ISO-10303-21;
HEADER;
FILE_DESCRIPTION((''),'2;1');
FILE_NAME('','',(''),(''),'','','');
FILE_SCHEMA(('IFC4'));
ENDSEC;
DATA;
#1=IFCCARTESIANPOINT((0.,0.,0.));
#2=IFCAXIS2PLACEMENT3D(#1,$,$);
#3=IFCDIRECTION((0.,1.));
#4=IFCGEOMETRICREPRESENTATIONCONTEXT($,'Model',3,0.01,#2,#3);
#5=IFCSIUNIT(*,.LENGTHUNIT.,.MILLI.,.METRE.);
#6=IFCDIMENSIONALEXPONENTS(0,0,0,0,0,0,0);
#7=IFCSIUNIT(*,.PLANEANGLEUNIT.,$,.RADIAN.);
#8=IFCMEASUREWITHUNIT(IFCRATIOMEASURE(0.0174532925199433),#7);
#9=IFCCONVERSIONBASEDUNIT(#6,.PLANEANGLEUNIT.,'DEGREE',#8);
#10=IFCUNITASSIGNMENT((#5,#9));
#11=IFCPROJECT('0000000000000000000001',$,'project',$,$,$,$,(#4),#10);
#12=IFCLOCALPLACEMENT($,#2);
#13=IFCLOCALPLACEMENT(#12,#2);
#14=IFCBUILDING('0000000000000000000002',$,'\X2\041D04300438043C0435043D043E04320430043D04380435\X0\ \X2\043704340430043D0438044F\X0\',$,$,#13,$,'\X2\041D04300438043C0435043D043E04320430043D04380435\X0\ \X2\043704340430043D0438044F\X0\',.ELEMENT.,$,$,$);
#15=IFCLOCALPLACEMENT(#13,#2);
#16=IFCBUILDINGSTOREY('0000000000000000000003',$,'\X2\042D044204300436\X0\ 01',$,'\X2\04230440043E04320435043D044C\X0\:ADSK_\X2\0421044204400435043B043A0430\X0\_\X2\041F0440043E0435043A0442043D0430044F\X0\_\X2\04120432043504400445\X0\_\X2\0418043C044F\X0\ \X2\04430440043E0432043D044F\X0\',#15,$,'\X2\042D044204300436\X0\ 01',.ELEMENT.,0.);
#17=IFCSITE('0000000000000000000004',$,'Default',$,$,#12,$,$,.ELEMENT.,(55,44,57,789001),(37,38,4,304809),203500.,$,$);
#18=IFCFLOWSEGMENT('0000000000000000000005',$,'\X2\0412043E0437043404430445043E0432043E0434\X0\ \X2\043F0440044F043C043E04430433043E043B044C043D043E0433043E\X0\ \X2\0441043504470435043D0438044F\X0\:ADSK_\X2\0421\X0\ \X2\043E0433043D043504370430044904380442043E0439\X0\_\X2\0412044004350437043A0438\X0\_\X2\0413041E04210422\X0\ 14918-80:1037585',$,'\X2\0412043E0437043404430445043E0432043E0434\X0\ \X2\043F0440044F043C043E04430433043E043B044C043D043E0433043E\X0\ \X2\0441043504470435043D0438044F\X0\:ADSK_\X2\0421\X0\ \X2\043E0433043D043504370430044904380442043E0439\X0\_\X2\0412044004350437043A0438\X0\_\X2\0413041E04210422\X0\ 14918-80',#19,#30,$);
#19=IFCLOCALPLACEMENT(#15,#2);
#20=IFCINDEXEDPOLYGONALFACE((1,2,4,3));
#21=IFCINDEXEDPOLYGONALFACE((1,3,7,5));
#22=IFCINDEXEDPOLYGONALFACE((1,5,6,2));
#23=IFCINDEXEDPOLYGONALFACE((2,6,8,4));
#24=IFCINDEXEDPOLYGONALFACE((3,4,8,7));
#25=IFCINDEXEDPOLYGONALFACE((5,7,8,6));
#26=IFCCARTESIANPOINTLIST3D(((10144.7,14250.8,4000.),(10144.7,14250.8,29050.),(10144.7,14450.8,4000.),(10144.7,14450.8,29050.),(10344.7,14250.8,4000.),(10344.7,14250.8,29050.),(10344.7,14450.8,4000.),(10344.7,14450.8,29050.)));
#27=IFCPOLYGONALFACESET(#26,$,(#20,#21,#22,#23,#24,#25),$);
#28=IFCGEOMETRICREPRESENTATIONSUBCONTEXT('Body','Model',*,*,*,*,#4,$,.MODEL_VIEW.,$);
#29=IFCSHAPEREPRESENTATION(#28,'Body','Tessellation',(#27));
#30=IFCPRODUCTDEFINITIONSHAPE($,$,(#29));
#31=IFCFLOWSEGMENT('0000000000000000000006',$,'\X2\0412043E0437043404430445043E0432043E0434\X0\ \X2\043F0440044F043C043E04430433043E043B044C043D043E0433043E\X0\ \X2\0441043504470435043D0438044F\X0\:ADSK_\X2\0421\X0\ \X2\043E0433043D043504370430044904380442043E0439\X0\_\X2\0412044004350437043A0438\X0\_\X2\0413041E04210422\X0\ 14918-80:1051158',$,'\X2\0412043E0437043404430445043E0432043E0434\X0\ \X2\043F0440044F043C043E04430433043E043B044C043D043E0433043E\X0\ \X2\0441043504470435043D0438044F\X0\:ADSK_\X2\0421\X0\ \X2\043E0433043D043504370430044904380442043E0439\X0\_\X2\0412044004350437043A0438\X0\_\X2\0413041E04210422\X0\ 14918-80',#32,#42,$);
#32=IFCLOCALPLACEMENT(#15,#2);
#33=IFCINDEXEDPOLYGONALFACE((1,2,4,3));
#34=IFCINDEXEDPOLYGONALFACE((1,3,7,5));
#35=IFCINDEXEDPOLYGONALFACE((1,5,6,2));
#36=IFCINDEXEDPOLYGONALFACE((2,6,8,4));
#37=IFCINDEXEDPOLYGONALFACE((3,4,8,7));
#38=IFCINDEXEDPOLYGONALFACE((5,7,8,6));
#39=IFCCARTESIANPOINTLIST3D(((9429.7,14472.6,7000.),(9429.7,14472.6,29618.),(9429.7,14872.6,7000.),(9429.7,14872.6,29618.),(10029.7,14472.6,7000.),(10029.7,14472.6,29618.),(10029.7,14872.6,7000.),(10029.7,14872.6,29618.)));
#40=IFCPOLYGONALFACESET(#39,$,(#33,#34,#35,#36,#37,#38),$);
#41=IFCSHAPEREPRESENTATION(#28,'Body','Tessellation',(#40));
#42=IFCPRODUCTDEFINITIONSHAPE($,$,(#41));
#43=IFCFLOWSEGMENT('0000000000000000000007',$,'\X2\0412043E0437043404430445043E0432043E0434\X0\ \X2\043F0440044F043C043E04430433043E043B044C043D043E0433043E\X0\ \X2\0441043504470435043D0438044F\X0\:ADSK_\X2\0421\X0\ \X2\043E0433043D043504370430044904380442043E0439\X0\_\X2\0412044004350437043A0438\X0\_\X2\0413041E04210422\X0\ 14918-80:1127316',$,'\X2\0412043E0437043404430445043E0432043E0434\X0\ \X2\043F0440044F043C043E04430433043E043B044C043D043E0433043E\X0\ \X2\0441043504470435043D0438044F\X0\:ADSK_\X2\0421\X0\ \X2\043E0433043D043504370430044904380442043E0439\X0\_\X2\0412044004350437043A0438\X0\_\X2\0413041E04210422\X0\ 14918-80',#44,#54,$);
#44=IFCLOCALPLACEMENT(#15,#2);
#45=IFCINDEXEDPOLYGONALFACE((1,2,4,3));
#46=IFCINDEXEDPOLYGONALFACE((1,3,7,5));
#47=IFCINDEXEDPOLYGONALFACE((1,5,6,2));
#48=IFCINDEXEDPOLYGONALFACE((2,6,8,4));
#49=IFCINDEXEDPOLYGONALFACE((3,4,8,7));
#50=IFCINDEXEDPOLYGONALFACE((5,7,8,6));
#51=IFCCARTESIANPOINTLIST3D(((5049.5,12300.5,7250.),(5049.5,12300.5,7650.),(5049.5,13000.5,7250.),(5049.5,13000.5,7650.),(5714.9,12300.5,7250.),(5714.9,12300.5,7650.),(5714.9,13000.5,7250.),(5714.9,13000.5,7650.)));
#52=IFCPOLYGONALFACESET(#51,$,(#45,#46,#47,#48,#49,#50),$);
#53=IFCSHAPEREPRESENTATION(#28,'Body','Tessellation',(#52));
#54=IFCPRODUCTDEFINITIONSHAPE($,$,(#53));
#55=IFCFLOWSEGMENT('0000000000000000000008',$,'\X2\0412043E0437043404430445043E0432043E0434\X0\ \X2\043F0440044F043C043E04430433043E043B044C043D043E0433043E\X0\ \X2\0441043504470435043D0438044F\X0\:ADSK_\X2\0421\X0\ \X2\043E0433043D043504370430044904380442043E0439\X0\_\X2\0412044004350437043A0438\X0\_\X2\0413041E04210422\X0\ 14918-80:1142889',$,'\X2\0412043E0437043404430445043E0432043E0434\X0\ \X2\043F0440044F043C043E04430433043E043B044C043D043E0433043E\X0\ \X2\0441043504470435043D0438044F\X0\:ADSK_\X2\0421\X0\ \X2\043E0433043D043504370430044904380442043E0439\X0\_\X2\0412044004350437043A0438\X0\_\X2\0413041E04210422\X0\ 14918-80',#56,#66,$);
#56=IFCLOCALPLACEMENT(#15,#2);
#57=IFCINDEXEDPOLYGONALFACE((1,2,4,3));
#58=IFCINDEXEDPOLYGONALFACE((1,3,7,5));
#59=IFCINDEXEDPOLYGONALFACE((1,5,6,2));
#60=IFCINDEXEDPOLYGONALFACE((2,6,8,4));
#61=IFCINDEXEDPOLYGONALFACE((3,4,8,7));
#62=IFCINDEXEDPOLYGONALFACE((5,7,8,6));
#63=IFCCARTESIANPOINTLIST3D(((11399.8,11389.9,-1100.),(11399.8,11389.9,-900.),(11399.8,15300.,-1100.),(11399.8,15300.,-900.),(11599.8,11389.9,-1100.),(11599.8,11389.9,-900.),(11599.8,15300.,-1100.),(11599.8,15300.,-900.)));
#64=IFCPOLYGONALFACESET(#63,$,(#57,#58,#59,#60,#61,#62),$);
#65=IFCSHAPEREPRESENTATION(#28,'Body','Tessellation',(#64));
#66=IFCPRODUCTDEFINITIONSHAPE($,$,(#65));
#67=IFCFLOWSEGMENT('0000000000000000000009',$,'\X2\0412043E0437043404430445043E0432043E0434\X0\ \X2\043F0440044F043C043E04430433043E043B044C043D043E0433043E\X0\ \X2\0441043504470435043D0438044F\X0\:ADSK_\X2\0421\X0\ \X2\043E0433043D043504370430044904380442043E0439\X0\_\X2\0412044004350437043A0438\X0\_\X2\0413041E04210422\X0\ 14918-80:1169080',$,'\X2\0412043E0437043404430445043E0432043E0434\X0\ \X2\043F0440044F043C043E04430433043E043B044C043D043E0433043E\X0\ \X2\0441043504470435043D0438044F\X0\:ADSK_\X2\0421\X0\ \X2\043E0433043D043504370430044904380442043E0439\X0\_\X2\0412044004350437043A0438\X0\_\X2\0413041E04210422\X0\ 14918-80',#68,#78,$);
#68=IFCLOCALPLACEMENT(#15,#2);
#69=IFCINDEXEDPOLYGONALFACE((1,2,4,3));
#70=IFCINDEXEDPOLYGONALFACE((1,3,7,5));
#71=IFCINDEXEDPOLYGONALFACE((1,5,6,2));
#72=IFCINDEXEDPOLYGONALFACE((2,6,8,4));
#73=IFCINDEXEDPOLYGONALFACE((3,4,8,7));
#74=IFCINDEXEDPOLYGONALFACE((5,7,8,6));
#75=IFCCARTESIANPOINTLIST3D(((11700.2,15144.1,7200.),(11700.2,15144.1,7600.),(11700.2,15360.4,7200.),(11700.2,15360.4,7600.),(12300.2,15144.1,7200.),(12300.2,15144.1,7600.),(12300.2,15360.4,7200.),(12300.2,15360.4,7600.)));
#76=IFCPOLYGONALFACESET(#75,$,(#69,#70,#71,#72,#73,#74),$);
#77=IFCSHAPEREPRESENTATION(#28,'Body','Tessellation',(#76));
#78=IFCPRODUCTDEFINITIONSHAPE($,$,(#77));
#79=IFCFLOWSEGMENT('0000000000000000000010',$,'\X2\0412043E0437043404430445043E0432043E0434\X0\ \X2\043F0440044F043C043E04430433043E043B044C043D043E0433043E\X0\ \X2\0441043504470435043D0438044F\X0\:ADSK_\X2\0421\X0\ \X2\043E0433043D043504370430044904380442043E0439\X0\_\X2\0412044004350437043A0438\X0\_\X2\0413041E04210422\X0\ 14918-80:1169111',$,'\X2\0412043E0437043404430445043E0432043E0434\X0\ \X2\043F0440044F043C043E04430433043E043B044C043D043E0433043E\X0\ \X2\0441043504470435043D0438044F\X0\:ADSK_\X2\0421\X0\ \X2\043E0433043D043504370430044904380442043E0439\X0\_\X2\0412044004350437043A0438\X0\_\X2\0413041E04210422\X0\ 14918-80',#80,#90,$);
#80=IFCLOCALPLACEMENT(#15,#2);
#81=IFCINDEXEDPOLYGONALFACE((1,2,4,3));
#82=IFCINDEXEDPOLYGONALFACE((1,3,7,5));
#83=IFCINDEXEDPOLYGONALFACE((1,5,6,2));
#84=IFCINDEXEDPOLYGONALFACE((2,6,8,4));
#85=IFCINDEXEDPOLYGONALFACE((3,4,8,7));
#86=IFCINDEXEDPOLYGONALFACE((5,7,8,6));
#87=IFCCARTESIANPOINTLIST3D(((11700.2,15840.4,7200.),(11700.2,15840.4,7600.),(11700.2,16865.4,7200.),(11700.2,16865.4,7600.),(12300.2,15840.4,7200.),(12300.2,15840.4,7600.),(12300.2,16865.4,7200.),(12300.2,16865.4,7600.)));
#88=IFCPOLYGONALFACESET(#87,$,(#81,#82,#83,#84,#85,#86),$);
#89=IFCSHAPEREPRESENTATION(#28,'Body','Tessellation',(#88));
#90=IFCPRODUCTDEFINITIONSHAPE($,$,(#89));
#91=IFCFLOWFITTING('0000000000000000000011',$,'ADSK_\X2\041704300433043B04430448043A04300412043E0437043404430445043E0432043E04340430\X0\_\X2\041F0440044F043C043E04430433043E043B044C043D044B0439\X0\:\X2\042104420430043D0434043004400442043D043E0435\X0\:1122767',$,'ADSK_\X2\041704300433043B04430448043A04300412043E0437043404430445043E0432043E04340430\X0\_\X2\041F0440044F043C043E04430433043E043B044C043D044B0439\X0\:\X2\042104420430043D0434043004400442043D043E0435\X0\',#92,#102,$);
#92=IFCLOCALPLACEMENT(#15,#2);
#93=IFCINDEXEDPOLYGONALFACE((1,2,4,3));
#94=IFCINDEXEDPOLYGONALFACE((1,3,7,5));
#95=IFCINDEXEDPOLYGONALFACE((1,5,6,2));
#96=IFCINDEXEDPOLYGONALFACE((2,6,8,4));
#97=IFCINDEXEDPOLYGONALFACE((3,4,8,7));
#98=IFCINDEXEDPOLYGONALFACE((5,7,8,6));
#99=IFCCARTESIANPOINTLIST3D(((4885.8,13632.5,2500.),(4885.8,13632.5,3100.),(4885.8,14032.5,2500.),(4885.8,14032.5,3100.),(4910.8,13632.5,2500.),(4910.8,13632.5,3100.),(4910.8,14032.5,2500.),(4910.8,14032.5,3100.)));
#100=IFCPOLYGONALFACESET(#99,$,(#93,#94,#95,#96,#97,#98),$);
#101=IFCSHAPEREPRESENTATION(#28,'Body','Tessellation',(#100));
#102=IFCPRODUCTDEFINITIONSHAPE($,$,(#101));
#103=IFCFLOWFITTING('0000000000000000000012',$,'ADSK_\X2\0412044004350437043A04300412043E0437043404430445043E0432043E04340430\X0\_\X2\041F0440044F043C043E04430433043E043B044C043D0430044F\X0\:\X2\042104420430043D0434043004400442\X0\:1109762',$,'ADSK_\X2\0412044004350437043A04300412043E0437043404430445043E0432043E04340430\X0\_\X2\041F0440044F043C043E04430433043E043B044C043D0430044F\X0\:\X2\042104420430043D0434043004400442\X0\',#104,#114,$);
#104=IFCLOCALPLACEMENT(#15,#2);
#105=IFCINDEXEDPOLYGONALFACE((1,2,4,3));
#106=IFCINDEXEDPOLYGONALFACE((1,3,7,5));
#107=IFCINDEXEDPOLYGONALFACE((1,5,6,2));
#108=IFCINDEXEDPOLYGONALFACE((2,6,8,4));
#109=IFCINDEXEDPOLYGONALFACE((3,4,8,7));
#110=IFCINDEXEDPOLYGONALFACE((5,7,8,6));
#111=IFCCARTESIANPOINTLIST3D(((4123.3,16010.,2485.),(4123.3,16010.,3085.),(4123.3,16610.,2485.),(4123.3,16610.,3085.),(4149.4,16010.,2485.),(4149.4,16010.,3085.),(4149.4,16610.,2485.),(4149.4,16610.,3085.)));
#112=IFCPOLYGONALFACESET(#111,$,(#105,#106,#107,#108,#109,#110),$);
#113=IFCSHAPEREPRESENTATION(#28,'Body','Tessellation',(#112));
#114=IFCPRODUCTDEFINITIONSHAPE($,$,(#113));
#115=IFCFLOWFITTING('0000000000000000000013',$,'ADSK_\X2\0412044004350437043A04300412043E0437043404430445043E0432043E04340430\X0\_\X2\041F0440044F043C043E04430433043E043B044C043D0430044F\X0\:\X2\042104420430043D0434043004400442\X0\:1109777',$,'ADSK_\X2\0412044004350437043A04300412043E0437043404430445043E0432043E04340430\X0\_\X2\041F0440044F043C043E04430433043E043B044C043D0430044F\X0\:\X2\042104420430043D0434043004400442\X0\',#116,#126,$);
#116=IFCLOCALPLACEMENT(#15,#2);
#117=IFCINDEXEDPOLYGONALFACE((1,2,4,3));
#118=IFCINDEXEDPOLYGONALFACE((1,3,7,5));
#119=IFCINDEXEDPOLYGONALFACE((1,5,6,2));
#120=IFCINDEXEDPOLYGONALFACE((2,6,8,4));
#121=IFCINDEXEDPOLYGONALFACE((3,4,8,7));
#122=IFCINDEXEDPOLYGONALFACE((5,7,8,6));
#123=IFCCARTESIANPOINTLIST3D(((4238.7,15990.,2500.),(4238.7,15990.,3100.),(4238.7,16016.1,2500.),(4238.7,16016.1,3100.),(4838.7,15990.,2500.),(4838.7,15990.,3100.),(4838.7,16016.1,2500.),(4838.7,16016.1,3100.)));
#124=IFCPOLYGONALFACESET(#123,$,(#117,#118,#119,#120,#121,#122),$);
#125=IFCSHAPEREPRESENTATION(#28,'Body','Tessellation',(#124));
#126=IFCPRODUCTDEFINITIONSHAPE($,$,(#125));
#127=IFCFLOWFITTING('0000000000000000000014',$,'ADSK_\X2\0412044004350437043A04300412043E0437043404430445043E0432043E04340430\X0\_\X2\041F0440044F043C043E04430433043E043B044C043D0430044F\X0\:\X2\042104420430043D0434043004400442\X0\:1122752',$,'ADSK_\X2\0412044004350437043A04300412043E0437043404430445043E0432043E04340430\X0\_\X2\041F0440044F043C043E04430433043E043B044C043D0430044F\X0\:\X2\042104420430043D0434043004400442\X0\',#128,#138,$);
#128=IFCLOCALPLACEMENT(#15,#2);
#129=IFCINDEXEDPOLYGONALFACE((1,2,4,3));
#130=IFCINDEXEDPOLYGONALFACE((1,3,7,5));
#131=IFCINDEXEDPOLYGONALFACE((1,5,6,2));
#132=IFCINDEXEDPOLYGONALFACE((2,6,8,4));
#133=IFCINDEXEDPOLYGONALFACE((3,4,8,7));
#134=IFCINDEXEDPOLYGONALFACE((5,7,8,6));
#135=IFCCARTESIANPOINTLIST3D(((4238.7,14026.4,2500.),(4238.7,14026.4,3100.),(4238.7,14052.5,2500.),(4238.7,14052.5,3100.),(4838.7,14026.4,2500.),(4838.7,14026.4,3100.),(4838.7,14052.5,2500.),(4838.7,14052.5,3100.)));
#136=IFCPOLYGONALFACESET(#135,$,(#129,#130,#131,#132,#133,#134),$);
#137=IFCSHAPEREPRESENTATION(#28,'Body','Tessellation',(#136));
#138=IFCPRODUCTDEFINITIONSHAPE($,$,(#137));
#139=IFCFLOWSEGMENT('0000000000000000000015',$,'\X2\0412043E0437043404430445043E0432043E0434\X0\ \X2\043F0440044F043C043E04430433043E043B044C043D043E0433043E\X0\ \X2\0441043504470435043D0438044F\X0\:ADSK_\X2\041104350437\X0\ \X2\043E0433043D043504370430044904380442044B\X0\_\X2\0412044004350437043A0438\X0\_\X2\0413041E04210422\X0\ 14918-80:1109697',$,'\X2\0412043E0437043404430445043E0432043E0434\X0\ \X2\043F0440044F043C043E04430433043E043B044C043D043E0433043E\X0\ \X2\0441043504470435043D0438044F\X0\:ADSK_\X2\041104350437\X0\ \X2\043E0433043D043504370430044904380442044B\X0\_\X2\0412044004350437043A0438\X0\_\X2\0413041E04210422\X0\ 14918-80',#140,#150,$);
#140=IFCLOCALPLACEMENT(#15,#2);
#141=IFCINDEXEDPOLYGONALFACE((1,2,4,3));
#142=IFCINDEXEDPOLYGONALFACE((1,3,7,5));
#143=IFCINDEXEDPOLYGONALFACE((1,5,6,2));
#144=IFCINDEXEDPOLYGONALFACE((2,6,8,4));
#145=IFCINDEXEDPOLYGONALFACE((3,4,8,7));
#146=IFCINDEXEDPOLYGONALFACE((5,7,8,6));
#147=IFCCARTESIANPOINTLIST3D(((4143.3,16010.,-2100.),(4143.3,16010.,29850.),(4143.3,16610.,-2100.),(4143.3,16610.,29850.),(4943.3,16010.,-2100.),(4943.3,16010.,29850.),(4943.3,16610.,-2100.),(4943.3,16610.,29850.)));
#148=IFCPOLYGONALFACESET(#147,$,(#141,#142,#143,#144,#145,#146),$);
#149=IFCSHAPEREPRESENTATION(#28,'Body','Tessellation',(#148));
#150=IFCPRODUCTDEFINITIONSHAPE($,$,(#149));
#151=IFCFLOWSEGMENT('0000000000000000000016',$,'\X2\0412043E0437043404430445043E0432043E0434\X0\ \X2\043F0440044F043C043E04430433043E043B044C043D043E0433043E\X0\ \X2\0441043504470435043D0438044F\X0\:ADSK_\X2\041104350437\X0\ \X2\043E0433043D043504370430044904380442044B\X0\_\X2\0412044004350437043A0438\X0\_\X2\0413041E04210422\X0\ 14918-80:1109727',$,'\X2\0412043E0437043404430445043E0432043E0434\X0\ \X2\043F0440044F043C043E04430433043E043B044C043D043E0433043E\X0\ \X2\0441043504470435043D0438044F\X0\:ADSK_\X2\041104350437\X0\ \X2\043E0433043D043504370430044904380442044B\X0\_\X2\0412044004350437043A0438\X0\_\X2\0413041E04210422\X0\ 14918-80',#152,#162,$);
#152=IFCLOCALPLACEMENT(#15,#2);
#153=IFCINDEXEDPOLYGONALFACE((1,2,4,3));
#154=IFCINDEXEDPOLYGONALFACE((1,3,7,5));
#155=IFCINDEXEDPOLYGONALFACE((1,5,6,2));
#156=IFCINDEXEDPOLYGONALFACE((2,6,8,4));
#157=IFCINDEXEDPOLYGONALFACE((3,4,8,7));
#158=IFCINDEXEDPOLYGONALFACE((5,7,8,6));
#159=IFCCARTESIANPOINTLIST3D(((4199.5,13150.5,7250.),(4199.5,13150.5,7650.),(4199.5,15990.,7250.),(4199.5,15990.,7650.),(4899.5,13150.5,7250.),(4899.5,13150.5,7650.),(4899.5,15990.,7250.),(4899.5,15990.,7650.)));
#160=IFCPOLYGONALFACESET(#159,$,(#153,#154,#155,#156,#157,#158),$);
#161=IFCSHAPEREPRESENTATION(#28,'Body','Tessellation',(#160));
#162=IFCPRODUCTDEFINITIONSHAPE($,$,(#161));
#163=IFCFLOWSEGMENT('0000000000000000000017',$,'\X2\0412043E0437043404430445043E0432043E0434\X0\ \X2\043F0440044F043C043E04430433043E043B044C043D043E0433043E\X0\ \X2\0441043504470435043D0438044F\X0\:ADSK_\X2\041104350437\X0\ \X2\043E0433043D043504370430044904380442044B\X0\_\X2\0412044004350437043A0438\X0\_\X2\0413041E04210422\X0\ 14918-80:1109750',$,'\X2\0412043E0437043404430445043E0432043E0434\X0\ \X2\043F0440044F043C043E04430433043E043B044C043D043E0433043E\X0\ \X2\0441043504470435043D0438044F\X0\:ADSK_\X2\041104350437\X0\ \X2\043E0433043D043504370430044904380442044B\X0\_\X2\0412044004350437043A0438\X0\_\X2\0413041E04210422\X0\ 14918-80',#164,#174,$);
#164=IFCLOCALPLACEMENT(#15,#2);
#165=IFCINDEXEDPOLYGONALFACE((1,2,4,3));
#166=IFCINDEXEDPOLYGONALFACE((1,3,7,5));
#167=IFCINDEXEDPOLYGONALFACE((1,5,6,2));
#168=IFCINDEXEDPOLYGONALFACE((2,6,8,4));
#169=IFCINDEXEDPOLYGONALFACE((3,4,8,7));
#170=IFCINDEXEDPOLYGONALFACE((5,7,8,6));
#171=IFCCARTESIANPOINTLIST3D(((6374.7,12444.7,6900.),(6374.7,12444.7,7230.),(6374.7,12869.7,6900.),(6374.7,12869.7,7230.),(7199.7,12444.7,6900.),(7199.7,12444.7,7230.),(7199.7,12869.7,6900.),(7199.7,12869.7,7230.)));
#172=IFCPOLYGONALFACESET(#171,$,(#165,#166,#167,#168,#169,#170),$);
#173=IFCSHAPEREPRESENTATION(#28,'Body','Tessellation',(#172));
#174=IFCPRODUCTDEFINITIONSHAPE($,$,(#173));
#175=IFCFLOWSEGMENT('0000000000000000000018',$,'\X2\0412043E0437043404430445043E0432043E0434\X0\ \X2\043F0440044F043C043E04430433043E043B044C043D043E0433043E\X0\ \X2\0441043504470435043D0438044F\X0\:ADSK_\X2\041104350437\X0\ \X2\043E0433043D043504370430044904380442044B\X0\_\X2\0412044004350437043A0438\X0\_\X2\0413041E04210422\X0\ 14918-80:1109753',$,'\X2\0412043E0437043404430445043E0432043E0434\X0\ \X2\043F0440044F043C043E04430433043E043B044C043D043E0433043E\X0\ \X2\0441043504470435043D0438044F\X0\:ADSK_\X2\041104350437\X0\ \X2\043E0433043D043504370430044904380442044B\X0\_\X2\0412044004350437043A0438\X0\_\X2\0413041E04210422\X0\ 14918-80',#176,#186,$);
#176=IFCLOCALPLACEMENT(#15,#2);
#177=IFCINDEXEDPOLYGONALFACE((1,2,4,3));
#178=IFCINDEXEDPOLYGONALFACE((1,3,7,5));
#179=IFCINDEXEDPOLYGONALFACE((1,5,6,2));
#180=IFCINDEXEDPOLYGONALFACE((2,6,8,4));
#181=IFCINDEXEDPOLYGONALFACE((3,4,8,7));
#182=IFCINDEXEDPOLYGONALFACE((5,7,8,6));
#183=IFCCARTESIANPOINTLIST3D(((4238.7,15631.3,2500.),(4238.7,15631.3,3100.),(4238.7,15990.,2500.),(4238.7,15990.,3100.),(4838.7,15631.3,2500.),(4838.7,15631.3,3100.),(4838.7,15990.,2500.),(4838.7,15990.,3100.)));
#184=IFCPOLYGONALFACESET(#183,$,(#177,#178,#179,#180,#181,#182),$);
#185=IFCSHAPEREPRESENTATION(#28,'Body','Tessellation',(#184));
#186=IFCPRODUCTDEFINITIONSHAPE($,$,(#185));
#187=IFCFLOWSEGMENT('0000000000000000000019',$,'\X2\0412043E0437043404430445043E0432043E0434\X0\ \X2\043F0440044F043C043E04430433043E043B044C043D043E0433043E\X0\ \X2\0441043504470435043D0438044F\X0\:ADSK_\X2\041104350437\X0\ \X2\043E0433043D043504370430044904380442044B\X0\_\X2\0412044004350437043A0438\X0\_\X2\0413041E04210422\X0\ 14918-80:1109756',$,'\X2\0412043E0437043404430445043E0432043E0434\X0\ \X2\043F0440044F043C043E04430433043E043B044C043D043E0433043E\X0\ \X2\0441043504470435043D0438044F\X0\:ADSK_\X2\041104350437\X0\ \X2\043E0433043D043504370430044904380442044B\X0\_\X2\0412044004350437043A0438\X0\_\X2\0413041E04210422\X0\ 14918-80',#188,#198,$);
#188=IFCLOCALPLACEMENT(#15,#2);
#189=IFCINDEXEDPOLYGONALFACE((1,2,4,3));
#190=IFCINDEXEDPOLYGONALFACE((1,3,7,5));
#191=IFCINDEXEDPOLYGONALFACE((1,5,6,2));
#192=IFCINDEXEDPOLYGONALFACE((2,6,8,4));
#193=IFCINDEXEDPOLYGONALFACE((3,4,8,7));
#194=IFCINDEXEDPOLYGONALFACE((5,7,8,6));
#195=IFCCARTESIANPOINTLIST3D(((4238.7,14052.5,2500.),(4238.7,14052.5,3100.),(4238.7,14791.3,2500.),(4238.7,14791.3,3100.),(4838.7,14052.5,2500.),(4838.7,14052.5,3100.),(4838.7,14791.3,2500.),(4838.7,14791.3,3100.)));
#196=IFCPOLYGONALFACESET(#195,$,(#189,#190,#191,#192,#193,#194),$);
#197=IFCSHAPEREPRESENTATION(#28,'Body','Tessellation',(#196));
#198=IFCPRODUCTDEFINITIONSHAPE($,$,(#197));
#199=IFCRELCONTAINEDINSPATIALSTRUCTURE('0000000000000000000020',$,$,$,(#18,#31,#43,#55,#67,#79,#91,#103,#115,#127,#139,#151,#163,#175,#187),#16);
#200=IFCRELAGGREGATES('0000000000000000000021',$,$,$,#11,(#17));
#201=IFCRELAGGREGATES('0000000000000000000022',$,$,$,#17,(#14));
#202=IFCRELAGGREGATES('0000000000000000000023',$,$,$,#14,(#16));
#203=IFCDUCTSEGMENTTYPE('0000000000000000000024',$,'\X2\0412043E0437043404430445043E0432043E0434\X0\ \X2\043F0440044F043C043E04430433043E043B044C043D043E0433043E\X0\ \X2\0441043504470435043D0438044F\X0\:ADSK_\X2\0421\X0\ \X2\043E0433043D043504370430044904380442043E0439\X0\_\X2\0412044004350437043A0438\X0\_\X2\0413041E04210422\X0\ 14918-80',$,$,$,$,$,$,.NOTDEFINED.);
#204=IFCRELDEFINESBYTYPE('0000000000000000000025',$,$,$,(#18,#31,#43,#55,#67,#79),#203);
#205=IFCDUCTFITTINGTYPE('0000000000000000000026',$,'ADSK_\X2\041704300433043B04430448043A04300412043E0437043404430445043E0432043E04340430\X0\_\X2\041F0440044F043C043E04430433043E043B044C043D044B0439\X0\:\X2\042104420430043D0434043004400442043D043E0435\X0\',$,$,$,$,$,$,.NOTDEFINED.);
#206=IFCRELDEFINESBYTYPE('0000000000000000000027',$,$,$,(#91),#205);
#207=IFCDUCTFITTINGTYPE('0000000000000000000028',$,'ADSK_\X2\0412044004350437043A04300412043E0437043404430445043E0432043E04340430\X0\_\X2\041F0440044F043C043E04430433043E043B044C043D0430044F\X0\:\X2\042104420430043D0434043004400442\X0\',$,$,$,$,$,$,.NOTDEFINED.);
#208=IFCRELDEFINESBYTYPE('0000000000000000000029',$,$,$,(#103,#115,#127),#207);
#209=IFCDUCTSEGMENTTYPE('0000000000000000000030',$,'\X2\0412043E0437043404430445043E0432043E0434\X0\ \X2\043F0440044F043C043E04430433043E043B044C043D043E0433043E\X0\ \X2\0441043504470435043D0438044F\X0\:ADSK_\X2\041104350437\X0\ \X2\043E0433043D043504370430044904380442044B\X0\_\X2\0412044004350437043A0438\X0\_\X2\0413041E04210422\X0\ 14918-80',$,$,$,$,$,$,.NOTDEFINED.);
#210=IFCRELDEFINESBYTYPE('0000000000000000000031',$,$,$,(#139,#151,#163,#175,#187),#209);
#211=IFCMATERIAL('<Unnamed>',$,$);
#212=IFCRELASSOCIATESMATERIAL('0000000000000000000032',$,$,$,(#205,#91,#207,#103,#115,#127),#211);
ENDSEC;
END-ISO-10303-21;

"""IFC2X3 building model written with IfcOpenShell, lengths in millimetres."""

from ifc_helpers import new_model, entity, si_unit, converted_unit, direction, frame, frame_2d, origin, origin_2d_with_axis, place, context, subcontext, project, spatial, rectangle, extrude, source, transform, mapped, material, type_object, type_shapes, element, save


model = new_model("IFC2X3")

# Units and contexts
model_context = context("Model", 3, precision=0.01, world=origin(), true_north=direction((0.0, 1.0)))
body_context = subcontext(model_context, "Body", "Model", "MODEL_VIEW")
ifc_project = project(units=[si_unit("LENGTHUNIT", "METRE", prefix="MILLI"), converted_unit("PLANEANGLEUNIT", "DEGREE", entity("IfcRatioMeasure", 0.0174532925199433), si_unit("PLANEANGLEUNIT", "RADIAN"), dimensions=[0, 0, 0, 0, 0, 0, 0])], contexts=[model_context])

# Site, building, storey
site_placement = place(None, frame((0.0, 0.0, 0.0)))
site = spatial("IfcSite", under=ifc_project, at=site_placement, Name="Default", CompositionType="ELEMENT", RefLatitude=(55, 44, 57, 789001), RefLongitude=(37, 38, 4, 304809), RefElevation=203500.0)
building_placement = place(site_placement, origin())
building = spatial("IfcBuilding", under=site, at=building_placement, Name="Наименование здания", LongName="Наименование здания", CompositionType="ELEMENT")
storey_placement = place(building_placement, origin())
storey = spatial("IfcBuildingStorey", under=building, at=storey_placement, Name="Этаж 01", ObjectType="Уровень:ADSK_Стрелка_Проектная_Вверх_Имя уровня", LongName="Этаж 01", CompositionType="ELEMENT", Elevation=0.0)

# Flow segments
duct_segment_type_1 = type_object("IfcDuctSegmentType", Name="Воздуховод прямоугольного сечения:ADSK_С огнезащитой_Врезки_ГОСТ 14918-80", PredefinedType="NOTDEFINED")
flow_segment_1_placement = place(storey_placement, frame((10144.7, 14250.8, 4000.0)))
element("IfcFlowSegment", 1, at=flow_segment_1_placement, inside=storey, type_object=duct_segment_type_1, Name="Воздуховод прямоугольного сечения:ADSK_С огнезащитой_Врезки_ГОСТ 14918-80:1037585", ObjectType="Воздуховод прямоугольного сечения:ADSK_С огнезащитой_Врезки_ГОСТ 14918-80", context=body_context, shape_type="SweptSolid", body=[
    extrude(rectangle(XDim=200.0, YDim=200.0, at=frame_2d((0.0, 0.0), x_axis=(1.0, 0.0))), frame((100.0, 100.0, 0.0), z_axis=(0.0, 0.0, 1.0), x_axis=(0.0, -1.0, 0.0)), (0.0, 0.0, 1.0), 25050.0),
])
flow_segment_2_placement = place(storey_placement, frame((9429.7, 14472.6, 7000.0)))
element("IfcFlowSegment", 2, at=flow_segment_2_placement, inside=storey, type_object=duct_segment_type_1, Name="Воздуховод прямоугольного сечения:ADSK_С огнезащитой_Врезки_ГОСТ 14918-80:1051158", ObjectType="Воздуховод прямоугольного сечения:ADSK_С огнезащитой_Врезки_ГОСТ 14918-80", context=body_context, shape_type="SweptSolid", body=[
    extrude(rectangle(XDim=400.0, YDim=600.0, at=frame_2d((0.0, 0.0), x_axis=(1.0, 0.0))), frame((300.0, 200.0, 0.0), z_axis=(0.0, 0.0, 1.0), x_axis=(0.0, 1.0, 0.0)), (0.0, 0.0, 1.0), 22618.0),
])
flow_segment_3_placement = place(storey_placement, frame((5049.5, 12300.5, 7250.0)))
element("IfcFlowSegment", 3, at=flow_segment_3_placement, inside=storey, type_object=duct_segment_type_1, Name="Воздуховод прямоугольного сечения:ADSK_С огнезащитой_Врезки_ГОСТ 14918-80:1127316", ObjectType="Воздуховод прямоугольного сечения:ADSK_С огнезащитой_Врезки_ГОСТ 14918-80", context=body_context, shape_type="SweptSolid", body=[
    extrude(rectangle(XDim=665.5, YDim=700.0, at=frame_2d((0.0, 0.0), x_axis=(1.0, 0.0))), frame((332.7, 350.0, 0.0), z_axis=(0.0, 0.0, 1.0), x_axis=(-1.0, 0.0, 0.0)), (0.0, 0.0, 1.0), 400.0),
])
flow_segment_4_placement = place(storey_placement, frame((11399.8, 11389.9, -1100.0)))
element("IfcFlowSegment", 4, at=flow_segment_4_placement, inside=storey, type_object=duct_segment_type_1, Name="Воздуховод прямоугольного сечения:ADSK_С огнезащитой_Врезки_ГОСТ 14918-80:1142889", ObjectType="Воздуховод прямоугольного сечения:ADSK_С огнезащитой_Врезки_ГОСТ 14918-80", context=body_context, shape_type="SweptSolid", body=[
    extrude(rectangle(XDim=3910.1, YDim=200.0, at=origin_2d_with_axis()), frame((100.0, 1955.0, 0.0), z_axis=(0.0, 0.0, 1.0), x_axis=(0.0, 1.0, 0.0)), (0.0, 0.0, 1.0), 200.0),
])
flow_segment_5_placement = place(storey_placement, frame((11700.2, 15144.1, 7200.0)))
element("IfcFlowSegment", 5, at=flow_segment_5_placement, inside=storey, type_object=duct_segment_type_1, Name="Воздуховод прямоугольного сечения:ADSK_С огнезащитой_Врезки_ГОСТ 14918-80:1169080", ObjectType="Воздуховод прямоугольного сечения:ADSK_С огнезащитой_Врезки_ГОСТ 14918-80", context=body_context, shape_type="SweptSolid", body=[
    extrude(rectangle(XDim=216.3, YDim=600.0, at=frame_2d((0.0, 0.0), x_axis=(1.0, 0.0))), frame((300.0, 108.1, 0.0), z_axis=(0.0, 0.0, 1.0), x_axis=(0.0, -1.0, 0.0)), (0.0, 0.0, 1.0), 400.0),
])
flow_segment_6_placement = place(storey_placement, frame((11700.2, 15840.4, 7200.0)))
element("IfcFlowSegment", 6, at=flow_segment_6_placement, inside=storey, type_object=duct_segment_type_1, Name="Воздуховод прямоугольного сечения:ADSK_С огнезащитой_Врезки_ГОСТ 14918-80:1169111", ObjectType="Воздуховод прямоугольного сечения:ADSK_С огнезащитой_Врезки_ГОСТ 14918-80", context=body_context, shape_type="SweptSolid", body=[
    extrude(rectangle(XDim=1025.0, YDim=600.0, at=frame_2d((0.0, 0.0), x_axis=(1.0, 0.0))), frame((300.0, 512.5, 0.0), z_axis=(0.0, 0.0, 1.0), x_axis=(0.0, 1.0, 0.0)), (0.0, 0.0, 1.0), 400.0),
])

# Flow fittings
ifc_material_1 = material(Name="<Unnamed>")
duct_fitting_type_1 = type_object("IfcDuctFittingType", Name="ADSK_ЗаглушкаВоздуховода_Прямоугольный:Стандартное", PredefinedType="NOTDEFINED", material=ifc_material_1)
shared_shape_1 = source(origin(), body_context, "Body", "SweptSolid", [
    extrude(rectangle(XDim=25.0, YDim=400.0, at=frame_2d((0.0, 0.0), x_axis=(1.0, 0.0))), frame((12.5, 0.0, -300.0)), (0.0, 0.0, 1.0), 600.0),
])
type_shapes(duct_fitting_type_1, [shared_shape_1])
flow_fitting_1_placement = place(storey_placement, frame((4885.8, 13832.5, 2800.0)))
element("IfcFlowFitting", 7, at=flow_fitting_1_placement, inside=storey, type_object=duct_fitting_type_1, material=ifc_material_1, Name="ADSK_ЗаглушкаВоздуховода_Прямоугольный:Стандартное:1122767", ObjectType="ADSK_ЗаглушкаВоздуховода_Прямоугольный:Стандартное", context=body_context, shape_type="MappedRepresentation", body=[
    mapped(shared_shape_1, transform((0.0, 0.0, 0.0), scale=1.0)),
])
duct_fitting_type_2 = type_object("IfcDuctFittingType", Name="ADSK_ВрезкаВоздуховода_Прямоугольная:Стандарт", PredefinedType="NOTDEFINED", material=ifc_material_1)
shared_shape_2 = source(origin(), body_context, "Body", "SweptSolid", [
    extrude(rectangle(XDim=26.1, YDim=600.0, at=frame_2d((0.0, 0.0), x_axis=(1.0, 0.0))), frame((7.0, 0.0, -300.0)), (0.0, 0.0, 1.0), 600.0),
])
type_shapes(duct_fitting_type_2, [shared_shape_2])
for number, where, z_axis, x_axis, name in (
    (8, (4143.3, 16310.0, 2785.0), (0.0, 1.0, 0.0), (-1.0, 0.0, 0.0), "ADSK_ВрезкаВоздуховода_Прямоугольная:Стандарт:1109762"),
    (9, (4538.7, 16010.0, 2800.0), (-1.0, 0.0, 0.0), (0.0, -1.0, 0.0), "ADSK_ВрезкаВоздуховода_Прямоугольная:Стандарт:1109777"),
    (10, (4538.7, 14032.5, 2800.0), (0.0, 0.0, -1.0), (0.0, 1.0, 0.0), "ADSK_ВрезкаВоздуховода_Прямоугольная:Стандарт:1122752"),
):
    element("IfcFlowFitting", number, at=place(storey_placement, frame(where, z_axis=z_axis, x_axis=x_axis)), inside=storey, type_object=duct_fitting_type_2, material=ifc_material_1, Name=name, ObjectType="ADSK_ВрезкаВоздуховода_Прямоугольная:Стандарт", context=body_context, shape_type="MappedRepresentation", body=[
        mapped(shared_shape_2, transform((0.0, 0.0, 0.0), scale=1.0)),
    ])

# Flow segments
duct_segment_type_2 = type_object("IfcDuctSegmentType", Name="Воздуховод прямоугольного сечения:ADSK_Без огнезащиты_Врезки_ГОСТ 14918-80", PredefinedType="NOTDEFINED")
flow_segment_7_placement = place(storey_placement, frame((4143.3, 16010.0, -2100.0)))
element("IfcFlowSegment", 11, at=flow_segment_7_placement, inside=storey, type_object=duct_segment_type_2, Name="Воздуховод прямоугольного сечения:ADSK_Без огнезащиты_Врезки_ГОСТ 14918-80:1109697", ObjectType="Воздуховод прямоугольного сечения:ADSK_Без огнезащиты_Врезки_ГОСТ 14918-80", context=body_context, shape_type="SweptSolid", body=[
    extrude(rectangle(XDim=600.0, YDim=800.0, at=frame_2d((0.0, 0.0), x_axis=(1.0, 0.0))), frame((400.0, 300.0, 0.0), z_axis=(0.0, 0.0, 1.0), x_axis=(0.0, 1.0, 0.0)), (0.0, 0.0, 1.0), 31950.0),
])
flow_segment_8_placement = place(storey_placement, frame((4199.5, 13150.5, 7250.0)))
element("IfcFlowSegment", 12, at=flow_segment_8_placement, inside=storey, type_object=duct_segment_type_2, Name="Воздуховод прямоугольного сечения:ADSK_Без огнезащиты_Врезки_ГОСТ 14918-80:1109727", ObjectType="Воздуховод прямоугольного сечения:ADSK_Без огнезащиты_Врезки_ГОСТ 14918-80", context=body_context, shape_type="SweptSolid", body=[
    extrude(rectangle(XDim=2839.5, YDim=700.0, at=frame_2d((0.0, 0.0), x_axis=(1.0, 0.0))), frame((350.0, 1419.8, 0.0), z_axis=(0.0, 0.0, 1.0), x_axis=(0.0, 1.0, 0.0)), (0.0, 0.0, 1.0), 400.0),
])
flow_segment_9_placement = place(storey_placement, frame((6374.7, 12444.7, 6900.0)))
element("IfcFlowSegment", 13, at=flow_segment_9_placement, inside=storey, type_object=duct_segment_type_2, Name="Воздуховод прямоугольного сечения:ADSK_Без огнезащиты_Врезки_ГОСТ 14918-80:1109750", ObjectType="Воздуховод прямоугольного сечения:ADSK_Без огнезащиты_Врезки_ГОСТ 14918-80", context=body_context, shape_type="SweptSolid", body=[
    extrude(rectangle(XDim=825.0, YDim=425.0, at=frame_2d((0.0, 0.0), x_axis=(1.0, 0.0))), frame((412.5, 212.5, 0.0), z_axis=(0.0, 0.0, 1.0), x_axis=(-1.0, 0.0, 0.0)), (0.0, 0.0, 1.0), 330.0),
])
flow_segment_10_placement = place(storey_placement, frame((4238.7, 15631.3, 2500.0)))
element("IfcFlowSegment", 14, at=flow_segment_10_placement, inside=storey, type_object=duct_segment_type_2, Name="Воздуховод прямоугольного сечения:ADSK_Без огнезащиты_Врезки_ГОСТ 14918-80:1109753", ObjectType="Воздуховод прямоугольного сечения:ADSK_Без огнезащиты_Врезки_ГОСТ 14918-80", context=body_context, shape_type="SweptSolid", body=[
    extrude(rectangle(XDim=358.6, YDim=600.0, at=frame_2d((0.0, 0.0), x_axis=(1.0, 0.0))), frame((300.0, 179.3, 0.0), z_axis=(0.0, 0.0, 1.0), x_axis=(0.0, 1.0, 0.0)), (0.0, 0.0, 1.0), 600.0),
])
flow_segment_11_placement = place(storey_placement, frame((4238.7, 14052.5, 2500.0)))
element("IfcFlowSegment", 15, at=flow_segment_11_placement, inside=storey, type_object=duct_segment_type_2, Name="Воздуховод прямоугольного сечения:ADSK_Без огнезащиты_Врезки_ГОСТ 14918-80:1109756", ObjectType="Воздуховод прямоугольного сечения:ADSK_Без огнезащиты_Врезки_ГОСТ 14918-80", context=body_context, shape_type="SweptSolid", body=[
    extrude(rectangle(XDim=738.8, YDim=600.0, at=origin_2d_with_axis()), frame((300.0, 369.4, 0.0), z_axis=(0.0, 0.0, 1.0), x_axis=(0.0, -1.0, 0.0)), (0.0, 0.0, 1.0), 600.0),
])

save(model, "model.ifc")
